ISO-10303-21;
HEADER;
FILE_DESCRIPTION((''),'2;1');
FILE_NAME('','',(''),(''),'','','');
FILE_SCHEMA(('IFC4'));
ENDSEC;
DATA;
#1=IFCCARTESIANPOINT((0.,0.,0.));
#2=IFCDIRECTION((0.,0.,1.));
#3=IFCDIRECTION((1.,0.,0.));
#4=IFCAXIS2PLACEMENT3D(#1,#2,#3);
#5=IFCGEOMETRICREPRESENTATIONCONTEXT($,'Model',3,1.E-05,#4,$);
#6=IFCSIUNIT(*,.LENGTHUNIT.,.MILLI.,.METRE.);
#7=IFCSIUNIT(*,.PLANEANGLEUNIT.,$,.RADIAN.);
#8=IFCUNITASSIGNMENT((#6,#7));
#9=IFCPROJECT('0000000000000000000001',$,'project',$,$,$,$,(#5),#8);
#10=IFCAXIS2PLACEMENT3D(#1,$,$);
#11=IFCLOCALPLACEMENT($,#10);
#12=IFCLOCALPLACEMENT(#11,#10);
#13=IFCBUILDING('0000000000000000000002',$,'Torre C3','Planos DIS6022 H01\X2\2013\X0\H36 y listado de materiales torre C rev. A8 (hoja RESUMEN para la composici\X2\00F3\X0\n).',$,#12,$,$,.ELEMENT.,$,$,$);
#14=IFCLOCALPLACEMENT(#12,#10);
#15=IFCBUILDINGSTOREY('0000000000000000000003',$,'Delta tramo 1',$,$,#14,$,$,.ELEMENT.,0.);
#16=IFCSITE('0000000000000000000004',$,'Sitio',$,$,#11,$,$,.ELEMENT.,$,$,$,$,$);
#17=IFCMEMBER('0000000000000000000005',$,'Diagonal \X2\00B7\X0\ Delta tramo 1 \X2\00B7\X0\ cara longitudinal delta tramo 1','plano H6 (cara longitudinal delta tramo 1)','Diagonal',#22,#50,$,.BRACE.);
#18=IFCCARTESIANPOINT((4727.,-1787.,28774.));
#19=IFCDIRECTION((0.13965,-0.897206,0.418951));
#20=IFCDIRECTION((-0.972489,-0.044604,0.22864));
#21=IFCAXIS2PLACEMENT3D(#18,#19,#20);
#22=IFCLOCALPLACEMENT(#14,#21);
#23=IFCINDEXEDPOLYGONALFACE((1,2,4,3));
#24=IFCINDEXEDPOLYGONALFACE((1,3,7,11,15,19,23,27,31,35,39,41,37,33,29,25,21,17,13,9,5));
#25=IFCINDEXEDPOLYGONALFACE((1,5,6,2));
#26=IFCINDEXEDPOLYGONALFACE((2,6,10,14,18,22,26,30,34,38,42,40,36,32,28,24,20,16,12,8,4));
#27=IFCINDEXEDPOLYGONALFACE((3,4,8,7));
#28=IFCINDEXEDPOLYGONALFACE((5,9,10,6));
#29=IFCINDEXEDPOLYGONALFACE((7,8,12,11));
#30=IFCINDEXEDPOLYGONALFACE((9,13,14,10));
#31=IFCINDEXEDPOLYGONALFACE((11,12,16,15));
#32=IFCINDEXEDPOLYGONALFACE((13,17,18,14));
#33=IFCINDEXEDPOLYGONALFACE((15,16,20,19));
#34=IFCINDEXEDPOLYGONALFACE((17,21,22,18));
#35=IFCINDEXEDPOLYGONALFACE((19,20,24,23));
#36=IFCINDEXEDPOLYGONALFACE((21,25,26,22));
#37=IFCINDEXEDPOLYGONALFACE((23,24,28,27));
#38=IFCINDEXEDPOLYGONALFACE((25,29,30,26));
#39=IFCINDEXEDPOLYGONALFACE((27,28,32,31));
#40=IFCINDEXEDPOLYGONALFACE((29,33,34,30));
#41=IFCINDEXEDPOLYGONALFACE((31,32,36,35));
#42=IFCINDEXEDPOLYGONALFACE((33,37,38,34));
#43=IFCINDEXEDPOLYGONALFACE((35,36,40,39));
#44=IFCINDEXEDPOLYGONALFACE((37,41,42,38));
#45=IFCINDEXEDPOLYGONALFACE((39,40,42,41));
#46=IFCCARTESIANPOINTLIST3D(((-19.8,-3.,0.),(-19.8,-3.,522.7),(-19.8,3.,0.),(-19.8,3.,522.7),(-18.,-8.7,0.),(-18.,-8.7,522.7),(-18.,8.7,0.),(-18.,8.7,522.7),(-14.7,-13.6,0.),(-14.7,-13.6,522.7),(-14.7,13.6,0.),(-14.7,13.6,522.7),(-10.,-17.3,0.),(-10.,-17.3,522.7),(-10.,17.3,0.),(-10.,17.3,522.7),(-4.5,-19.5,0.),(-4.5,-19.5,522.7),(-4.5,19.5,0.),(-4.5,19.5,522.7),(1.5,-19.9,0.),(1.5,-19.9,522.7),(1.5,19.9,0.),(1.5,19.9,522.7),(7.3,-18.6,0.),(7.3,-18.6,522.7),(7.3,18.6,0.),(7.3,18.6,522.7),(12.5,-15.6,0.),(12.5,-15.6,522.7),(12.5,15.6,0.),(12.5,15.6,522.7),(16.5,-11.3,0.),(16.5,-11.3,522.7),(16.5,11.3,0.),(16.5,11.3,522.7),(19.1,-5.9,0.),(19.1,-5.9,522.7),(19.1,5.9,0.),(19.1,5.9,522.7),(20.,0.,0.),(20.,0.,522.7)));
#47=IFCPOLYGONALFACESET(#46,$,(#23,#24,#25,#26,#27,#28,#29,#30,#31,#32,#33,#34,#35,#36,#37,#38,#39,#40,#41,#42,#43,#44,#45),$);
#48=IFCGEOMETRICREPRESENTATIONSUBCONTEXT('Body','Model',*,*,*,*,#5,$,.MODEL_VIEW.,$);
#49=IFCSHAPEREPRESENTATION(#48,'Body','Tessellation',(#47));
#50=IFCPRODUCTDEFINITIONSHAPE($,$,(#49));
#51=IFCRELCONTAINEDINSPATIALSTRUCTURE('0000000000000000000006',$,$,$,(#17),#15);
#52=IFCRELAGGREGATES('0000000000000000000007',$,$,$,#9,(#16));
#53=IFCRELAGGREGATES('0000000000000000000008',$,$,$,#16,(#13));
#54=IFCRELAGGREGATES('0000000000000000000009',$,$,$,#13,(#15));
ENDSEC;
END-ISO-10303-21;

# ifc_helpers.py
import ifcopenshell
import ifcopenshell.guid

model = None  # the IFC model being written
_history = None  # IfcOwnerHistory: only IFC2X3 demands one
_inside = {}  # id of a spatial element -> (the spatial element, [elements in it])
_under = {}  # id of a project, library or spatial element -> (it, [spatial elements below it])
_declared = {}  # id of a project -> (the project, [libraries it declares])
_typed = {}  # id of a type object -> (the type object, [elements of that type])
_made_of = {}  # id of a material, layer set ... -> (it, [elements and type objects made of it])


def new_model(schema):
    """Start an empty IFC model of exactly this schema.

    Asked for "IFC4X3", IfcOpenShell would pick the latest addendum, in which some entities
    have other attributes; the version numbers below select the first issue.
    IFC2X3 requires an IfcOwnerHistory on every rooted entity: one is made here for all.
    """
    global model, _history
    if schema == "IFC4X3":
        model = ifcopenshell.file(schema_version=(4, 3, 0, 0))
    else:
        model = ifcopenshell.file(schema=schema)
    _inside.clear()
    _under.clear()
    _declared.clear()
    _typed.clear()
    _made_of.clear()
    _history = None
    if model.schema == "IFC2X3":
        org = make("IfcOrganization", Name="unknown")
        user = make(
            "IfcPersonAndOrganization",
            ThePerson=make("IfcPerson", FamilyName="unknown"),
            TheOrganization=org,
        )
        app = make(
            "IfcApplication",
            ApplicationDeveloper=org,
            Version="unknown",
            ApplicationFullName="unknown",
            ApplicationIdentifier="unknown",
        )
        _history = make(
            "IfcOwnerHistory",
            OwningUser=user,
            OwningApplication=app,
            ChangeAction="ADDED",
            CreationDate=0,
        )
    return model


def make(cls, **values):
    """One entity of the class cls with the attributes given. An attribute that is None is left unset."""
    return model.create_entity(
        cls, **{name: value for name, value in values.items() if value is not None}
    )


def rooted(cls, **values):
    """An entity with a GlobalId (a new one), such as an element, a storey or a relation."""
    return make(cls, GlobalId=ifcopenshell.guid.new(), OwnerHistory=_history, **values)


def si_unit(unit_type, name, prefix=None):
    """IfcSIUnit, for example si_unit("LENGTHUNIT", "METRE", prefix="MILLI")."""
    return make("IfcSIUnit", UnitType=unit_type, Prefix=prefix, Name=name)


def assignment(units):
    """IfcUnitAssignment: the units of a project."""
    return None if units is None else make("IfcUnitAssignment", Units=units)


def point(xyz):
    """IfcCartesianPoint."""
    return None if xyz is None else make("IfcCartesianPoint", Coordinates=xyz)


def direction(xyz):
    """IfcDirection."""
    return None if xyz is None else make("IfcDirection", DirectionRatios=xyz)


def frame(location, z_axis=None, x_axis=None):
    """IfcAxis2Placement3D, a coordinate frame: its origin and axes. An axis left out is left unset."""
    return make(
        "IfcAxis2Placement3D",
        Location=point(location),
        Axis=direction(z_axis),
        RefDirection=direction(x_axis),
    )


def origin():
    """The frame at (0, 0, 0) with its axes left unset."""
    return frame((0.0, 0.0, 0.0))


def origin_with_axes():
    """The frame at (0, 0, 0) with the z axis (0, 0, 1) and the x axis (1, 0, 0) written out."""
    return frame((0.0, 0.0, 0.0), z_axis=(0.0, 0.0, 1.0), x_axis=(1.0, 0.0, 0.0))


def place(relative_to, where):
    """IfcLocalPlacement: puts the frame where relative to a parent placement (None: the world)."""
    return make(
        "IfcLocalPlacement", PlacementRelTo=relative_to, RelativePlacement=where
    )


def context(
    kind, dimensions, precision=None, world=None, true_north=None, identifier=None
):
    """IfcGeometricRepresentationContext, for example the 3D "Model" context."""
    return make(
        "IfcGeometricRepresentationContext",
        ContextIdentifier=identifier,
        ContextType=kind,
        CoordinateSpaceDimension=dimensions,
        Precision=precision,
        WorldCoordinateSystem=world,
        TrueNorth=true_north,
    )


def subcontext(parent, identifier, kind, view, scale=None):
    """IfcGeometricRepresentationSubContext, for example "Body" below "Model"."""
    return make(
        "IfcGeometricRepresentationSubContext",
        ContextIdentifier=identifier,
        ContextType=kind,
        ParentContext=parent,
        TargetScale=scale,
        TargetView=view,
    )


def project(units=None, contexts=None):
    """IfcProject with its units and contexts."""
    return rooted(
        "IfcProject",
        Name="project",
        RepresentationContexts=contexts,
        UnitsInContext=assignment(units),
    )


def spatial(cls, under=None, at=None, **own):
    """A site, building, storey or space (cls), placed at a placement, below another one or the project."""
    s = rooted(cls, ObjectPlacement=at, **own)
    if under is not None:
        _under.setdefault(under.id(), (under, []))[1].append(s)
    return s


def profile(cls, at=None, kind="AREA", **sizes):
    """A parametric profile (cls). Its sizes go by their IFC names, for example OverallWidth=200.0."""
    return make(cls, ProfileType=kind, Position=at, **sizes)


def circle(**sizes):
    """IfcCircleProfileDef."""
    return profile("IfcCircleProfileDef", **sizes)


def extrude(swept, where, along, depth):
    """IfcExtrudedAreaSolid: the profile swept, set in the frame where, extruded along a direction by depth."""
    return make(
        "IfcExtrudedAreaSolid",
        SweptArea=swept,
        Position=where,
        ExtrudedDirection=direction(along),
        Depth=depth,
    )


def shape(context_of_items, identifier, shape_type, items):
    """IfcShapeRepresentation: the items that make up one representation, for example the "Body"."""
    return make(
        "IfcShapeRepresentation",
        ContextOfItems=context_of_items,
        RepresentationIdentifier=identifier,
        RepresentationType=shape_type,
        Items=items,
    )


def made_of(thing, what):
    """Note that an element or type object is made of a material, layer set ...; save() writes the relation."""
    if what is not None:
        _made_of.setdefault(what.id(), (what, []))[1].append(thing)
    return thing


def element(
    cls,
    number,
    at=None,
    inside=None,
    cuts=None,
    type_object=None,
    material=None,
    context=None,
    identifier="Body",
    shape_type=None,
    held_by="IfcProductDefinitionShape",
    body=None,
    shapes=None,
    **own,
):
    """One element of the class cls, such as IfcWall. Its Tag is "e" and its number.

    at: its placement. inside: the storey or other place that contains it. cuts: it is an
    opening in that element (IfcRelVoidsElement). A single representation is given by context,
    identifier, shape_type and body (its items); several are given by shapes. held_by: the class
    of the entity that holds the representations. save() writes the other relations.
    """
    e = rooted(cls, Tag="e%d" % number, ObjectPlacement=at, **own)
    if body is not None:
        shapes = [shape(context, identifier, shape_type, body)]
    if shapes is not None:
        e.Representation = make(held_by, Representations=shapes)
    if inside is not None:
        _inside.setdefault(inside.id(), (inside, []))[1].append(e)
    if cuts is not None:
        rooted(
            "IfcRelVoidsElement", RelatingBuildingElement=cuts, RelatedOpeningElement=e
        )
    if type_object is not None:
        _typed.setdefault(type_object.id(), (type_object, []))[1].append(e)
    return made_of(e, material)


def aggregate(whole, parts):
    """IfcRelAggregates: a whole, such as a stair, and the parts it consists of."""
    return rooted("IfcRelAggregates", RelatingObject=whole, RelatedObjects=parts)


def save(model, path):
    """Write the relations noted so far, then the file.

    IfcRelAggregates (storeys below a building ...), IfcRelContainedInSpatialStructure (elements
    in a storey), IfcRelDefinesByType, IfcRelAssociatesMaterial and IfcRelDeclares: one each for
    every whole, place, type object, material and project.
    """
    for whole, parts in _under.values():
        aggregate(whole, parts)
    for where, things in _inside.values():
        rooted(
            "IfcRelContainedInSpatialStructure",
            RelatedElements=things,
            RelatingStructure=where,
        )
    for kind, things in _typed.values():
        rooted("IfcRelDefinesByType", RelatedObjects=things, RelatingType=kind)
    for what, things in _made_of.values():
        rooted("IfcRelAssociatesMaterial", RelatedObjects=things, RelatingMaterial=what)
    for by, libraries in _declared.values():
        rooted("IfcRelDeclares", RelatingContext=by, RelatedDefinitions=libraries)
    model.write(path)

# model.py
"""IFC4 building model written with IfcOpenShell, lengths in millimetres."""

from ifc_helpers import new_model, si_unit, frame, origin, origin_with_axes, place, context, subcontext, project, spatial, circle, extrude, element, save


model = new_model("IFC4")

# Units and contexts
model_context = context("Model", 3, precision=1e-05, world=origin_with_axes())
body_context = subcontext(model_context, "Body", "Model", "MODEL_VIEW")
ifc_project = project(units=[si_unit("LENGTHUNIT", "METRE", prefix="MILLI"), si_unit("PLANEANGLEUNIT", "RADIAN")], contexts=[model_context])

# Site, building, storey
site_placement = place(None, origin())
site = spatial("IfcSite", under=ifc_project, at=site_placement, Name="Sitio", CompositionType="ELEMENT")
building_placement = place(site_placement, origin())
building = spatial("IfcBuilding", under=site, at=building_placement, Name="Torre C3", Description="Planos DIS6022 H01–H36 y listado de materiales torre C rev. A8 (hoja RESUMEN para la composición).", CompositionType="ELEMENT")
storey_placement = place(building_placement, origin())
storey = spatial("IfcBuildingStorey", under=building, at=storey_placement, Name="Delta tramo 1", CompositionType="ELEMENT", Elevation=0.0)

# Member
member_1_placement = place(storey_placement, frame((4727.0, -1787.0, 28774.0), z_axis=(0.13965, -0.897206, 0.418951), x_axis=(-0.972489, -0.044604, 0.22864)))
element("IfcMember", 1, at=member_1_placement, inside=storey, Name="Diagonal · Delta tramo 1 · cara longitudinal delta tramo 1", Description="plano H6 (cara longitudinal delta tramo 1)", ObjectType="Diagonal", PredefinedType="BRACE", context=body_context, shape_type="SweptSolid", body=[
    extrude(circle(Radius=20.0), None, (0.0, 0.0, 1.0), 522.7),
])

save(model, "model.ifc")
